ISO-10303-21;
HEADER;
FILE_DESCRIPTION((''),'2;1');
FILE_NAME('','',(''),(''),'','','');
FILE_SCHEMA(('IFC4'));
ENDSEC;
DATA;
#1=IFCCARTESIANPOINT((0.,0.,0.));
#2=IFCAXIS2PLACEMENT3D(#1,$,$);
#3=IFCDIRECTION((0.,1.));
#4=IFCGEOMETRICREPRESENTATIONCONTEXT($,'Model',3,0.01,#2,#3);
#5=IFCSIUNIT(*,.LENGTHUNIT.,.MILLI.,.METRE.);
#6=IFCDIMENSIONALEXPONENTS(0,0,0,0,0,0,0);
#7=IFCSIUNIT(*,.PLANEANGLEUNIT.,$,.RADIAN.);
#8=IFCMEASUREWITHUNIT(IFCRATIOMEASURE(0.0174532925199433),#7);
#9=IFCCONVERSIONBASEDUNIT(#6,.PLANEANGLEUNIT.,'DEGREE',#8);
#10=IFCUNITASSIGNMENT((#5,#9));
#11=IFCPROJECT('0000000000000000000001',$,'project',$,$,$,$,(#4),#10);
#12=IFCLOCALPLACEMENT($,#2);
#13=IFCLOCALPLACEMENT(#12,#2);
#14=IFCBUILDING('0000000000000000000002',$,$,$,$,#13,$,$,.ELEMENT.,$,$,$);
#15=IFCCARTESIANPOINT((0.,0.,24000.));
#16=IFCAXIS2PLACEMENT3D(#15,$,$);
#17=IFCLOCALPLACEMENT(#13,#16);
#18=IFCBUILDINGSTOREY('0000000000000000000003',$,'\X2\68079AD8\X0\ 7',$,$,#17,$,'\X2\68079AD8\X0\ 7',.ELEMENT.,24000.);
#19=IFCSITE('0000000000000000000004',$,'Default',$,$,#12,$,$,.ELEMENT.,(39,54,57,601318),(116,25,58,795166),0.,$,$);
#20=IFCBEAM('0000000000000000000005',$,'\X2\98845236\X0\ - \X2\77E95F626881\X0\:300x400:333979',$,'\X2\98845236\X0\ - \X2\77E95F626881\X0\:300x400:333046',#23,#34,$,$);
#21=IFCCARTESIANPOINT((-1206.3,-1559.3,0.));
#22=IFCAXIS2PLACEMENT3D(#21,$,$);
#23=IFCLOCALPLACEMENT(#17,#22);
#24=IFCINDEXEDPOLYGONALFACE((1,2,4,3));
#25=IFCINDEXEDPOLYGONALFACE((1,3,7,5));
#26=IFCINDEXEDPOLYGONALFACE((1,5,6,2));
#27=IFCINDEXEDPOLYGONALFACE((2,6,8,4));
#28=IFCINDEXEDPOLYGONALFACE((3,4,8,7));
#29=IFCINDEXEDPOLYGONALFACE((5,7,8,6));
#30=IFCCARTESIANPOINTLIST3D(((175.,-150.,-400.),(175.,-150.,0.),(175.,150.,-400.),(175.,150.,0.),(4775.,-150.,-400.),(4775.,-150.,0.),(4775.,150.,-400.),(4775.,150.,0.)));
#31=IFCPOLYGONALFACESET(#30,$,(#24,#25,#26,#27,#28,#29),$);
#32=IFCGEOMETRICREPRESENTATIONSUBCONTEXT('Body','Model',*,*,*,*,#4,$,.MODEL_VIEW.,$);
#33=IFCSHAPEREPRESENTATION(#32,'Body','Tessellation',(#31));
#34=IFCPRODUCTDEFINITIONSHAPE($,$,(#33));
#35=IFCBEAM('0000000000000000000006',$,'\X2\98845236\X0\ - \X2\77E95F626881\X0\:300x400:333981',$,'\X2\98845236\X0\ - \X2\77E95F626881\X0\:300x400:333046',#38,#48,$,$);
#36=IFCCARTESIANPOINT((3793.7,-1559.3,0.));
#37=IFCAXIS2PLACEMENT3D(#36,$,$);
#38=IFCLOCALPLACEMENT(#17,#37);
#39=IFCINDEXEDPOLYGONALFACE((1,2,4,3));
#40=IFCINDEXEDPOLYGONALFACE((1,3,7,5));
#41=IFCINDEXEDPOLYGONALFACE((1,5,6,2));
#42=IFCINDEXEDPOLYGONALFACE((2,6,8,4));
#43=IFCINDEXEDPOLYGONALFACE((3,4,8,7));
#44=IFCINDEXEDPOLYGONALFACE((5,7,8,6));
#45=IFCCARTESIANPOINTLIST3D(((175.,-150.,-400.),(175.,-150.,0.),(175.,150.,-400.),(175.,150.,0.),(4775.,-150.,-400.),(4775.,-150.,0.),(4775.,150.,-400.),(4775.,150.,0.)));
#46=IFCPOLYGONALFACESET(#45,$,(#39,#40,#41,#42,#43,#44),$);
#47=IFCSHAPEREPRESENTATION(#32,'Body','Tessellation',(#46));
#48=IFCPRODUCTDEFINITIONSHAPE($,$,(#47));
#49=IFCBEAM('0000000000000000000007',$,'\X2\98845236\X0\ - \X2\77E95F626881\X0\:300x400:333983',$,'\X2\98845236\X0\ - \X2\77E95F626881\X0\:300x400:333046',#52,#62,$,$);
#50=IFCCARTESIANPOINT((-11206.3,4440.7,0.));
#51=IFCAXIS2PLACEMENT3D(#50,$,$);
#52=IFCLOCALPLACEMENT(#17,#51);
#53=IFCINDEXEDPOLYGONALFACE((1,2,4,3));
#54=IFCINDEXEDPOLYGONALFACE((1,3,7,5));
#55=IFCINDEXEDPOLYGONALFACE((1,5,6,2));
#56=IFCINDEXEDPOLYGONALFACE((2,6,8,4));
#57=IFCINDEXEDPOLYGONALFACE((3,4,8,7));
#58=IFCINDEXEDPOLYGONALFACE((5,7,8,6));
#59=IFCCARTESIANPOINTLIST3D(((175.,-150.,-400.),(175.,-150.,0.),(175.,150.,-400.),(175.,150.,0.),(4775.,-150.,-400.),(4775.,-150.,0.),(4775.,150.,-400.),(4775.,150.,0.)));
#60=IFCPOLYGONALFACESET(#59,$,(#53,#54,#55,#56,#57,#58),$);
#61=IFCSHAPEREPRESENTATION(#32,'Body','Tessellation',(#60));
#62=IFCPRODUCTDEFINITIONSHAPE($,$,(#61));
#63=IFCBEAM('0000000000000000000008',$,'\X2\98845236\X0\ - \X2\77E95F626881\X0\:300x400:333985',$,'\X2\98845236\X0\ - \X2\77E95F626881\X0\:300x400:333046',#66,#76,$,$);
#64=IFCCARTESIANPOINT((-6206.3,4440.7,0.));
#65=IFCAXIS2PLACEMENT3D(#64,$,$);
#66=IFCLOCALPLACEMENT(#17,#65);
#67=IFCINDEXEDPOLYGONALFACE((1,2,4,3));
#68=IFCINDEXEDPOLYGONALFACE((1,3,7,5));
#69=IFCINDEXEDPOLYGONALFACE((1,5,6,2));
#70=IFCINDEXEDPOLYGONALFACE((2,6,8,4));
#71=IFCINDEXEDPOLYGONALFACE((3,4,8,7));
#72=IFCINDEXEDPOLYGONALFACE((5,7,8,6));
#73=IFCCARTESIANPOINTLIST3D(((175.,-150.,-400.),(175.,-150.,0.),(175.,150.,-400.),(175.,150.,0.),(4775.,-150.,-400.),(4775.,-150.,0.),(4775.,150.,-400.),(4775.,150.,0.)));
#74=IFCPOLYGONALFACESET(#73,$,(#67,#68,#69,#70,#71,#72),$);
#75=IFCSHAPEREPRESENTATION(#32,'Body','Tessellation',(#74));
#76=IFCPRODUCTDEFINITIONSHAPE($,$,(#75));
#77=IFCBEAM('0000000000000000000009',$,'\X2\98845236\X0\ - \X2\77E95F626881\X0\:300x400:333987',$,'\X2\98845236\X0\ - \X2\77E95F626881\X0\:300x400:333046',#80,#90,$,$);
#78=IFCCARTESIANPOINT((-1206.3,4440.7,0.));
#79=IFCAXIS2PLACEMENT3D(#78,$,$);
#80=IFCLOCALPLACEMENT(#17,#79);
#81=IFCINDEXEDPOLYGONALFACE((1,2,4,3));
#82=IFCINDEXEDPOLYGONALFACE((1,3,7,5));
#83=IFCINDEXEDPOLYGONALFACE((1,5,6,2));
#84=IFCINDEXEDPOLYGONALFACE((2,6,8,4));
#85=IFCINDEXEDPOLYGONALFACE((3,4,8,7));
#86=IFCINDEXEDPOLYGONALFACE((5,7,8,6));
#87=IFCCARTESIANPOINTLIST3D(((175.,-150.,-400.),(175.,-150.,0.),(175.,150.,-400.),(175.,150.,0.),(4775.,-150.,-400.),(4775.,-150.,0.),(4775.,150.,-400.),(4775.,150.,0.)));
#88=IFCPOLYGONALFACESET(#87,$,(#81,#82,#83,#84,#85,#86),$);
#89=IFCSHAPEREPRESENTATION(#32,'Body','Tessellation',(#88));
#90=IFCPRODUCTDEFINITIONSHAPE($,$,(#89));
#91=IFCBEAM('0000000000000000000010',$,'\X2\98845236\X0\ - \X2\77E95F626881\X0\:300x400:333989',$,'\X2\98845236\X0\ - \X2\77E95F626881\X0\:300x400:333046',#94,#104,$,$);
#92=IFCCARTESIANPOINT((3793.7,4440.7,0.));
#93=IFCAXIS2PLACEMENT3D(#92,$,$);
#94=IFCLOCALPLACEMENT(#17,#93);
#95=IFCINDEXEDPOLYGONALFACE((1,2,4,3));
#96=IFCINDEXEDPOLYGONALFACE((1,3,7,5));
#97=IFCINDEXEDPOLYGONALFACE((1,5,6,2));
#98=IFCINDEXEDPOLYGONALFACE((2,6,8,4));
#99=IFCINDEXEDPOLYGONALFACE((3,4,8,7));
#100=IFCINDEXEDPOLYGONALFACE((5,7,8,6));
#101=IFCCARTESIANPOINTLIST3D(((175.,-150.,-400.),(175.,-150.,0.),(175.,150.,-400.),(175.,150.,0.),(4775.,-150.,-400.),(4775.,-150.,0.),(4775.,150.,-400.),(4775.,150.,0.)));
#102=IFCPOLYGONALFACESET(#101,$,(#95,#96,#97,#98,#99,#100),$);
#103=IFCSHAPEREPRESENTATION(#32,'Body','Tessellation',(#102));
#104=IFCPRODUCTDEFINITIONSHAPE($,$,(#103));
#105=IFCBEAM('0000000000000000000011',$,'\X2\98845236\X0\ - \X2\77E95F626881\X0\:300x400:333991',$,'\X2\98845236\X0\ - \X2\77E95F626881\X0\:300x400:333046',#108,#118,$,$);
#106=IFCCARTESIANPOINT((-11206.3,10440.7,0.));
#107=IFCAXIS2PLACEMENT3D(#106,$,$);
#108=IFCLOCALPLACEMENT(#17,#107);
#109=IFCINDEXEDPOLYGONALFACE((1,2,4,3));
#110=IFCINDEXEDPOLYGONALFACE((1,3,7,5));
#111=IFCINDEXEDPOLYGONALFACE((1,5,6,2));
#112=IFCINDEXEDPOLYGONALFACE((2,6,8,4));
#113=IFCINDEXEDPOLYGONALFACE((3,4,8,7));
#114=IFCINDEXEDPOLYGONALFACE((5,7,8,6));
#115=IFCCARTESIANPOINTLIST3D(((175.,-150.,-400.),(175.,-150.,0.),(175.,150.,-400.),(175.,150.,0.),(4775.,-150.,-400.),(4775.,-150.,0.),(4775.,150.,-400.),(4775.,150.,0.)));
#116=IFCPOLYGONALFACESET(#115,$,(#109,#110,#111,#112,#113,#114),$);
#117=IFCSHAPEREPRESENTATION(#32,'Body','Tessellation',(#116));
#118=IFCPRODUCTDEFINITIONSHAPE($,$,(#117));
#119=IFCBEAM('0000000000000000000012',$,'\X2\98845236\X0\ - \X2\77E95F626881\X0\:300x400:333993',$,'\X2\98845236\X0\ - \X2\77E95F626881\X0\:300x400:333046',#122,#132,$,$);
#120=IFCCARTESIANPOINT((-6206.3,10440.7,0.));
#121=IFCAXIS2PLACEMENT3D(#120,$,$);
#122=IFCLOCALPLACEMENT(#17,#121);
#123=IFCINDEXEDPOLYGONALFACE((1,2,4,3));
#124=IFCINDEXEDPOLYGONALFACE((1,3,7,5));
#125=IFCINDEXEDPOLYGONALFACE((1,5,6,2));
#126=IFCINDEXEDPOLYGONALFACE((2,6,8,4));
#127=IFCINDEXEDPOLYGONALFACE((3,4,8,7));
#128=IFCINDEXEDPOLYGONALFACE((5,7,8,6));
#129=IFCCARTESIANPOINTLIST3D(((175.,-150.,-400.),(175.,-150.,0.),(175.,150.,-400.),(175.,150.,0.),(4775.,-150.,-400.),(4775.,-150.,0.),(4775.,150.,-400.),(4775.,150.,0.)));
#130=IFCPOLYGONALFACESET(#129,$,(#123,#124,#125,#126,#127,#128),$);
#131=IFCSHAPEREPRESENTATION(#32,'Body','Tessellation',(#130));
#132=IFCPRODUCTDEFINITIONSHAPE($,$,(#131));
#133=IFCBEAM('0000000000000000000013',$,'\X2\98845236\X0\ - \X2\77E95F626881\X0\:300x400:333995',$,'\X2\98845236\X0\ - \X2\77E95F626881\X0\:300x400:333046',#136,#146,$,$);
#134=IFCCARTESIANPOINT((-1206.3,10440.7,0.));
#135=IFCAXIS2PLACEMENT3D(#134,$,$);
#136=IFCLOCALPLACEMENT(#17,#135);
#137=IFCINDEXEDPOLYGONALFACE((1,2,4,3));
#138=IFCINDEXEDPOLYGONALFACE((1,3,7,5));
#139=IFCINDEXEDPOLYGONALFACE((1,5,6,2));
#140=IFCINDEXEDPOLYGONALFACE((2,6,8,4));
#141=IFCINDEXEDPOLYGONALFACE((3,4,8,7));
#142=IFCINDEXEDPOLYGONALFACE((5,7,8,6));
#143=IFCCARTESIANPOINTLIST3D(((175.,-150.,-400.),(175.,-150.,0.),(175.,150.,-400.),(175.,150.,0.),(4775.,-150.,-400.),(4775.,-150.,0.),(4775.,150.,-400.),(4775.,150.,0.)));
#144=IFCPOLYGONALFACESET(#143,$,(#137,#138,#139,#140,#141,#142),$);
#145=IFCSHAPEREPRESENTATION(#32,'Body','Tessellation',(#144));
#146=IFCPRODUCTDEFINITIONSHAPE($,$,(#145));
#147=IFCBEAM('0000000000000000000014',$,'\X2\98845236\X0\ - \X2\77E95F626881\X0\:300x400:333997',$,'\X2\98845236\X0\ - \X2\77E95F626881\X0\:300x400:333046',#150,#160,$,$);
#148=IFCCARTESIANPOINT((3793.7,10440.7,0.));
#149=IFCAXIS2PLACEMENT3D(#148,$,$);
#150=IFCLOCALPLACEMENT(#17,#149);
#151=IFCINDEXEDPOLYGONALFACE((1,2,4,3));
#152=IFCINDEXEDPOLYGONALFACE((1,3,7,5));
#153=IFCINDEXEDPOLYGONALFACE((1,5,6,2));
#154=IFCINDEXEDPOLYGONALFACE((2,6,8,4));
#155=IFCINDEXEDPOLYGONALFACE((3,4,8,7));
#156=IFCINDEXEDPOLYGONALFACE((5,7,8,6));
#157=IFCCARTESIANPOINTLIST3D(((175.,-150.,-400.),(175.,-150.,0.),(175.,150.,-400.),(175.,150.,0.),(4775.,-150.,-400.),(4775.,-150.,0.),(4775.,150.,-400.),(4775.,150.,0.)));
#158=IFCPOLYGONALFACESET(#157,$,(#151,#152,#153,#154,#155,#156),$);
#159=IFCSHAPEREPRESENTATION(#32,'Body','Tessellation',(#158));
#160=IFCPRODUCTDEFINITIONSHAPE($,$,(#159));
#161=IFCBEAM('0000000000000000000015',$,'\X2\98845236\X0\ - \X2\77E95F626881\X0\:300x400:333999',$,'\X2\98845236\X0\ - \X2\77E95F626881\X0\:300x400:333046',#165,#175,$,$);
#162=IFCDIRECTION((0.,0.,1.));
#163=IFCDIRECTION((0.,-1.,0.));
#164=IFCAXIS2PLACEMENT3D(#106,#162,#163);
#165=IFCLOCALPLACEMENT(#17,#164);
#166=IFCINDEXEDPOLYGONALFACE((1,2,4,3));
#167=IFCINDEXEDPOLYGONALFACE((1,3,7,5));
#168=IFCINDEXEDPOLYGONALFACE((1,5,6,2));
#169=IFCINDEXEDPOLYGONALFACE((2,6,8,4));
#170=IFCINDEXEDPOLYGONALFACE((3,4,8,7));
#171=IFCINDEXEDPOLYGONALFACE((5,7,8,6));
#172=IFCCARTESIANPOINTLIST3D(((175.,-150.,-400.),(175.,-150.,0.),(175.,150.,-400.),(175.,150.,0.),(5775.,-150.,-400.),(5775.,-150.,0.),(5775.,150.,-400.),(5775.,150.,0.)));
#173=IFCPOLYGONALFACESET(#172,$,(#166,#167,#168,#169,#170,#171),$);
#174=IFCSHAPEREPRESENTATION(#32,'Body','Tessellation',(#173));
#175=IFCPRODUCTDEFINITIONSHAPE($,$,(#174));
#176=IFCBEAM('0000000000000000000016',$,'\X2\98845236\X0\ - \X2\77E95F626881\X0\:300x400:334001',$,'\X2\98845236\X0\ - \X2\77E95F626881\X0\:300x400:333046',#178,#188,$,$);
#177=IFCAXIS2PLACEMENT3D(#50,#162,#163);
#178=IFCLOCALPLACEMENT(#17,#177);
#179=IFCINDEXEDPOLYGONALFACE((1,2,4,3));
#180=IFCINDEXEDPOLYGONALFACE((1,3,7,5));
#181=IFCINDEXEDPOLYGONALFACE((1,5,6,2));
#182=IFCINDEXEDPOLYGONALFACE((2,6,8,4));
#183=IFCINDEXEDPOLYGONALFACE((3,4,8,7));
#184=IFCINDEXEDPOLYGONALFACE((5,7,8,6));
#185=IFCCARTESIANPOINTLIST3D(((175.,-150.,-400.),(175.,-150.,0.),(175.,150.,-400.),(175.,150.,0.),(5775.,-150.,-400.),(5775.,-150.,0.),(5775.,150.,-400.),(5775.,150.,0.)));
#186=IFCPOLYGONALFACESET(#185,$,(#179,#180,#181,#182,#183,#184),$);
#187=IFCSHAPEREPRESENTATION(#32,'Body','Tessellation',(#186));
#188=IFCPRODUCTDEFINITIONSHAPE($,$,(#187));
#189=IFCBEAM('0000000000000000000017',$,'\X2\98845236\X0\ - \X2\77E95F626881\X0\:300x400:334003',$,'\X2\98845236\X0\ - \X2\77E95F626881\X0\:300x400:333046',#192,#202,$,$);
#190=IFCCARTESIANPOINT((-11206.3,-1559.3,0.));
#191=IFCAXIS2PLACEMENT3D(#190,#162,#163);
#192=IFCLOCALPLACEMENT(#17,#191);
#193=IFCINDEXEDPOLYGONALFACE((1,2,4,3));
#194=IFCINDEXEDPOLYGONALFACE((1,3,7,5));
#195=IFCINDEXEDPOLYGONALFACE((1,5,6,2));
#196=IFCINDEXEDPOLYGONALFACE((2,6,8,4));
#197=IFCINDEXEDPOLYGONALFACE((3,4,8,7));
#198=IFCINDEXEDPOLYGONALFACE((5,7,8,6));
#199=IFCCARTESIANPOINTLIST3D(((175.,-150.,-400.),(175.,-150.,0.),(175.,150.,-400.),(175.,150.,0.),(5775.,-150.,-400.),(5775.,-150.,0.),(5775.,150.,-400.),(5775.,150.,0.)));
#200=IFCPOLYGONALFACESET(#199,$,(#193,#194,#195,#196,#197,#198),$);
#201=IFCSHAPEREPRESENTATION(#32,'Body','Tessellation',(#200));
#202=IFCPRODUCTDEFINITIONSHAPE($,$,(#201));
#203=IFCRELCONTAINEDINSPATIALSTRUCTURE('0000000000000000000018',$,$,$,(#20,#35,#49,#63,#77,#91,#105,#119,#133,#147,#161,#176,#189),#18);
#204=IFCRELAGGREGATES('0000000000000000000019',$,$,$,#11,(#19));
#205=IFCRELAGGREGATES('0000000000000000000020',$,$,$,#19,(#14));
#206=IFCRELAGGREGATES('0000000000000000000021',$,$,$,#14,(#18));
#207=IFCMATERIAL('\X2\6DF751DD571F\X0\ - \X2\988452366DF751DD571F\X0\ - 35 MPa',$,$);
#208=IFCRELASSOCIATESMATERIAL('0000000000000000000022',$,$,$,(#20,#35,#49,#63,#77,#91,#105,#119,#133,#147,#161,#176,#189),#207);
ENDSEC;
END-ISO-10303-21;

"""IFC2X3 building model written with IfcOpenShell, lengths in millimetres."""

from ifc_helpers import new_model, entity, si_unit, converted_unit, direction, frame, frame_2d, origin, origin_2d_with_axis, place, context, subcontext, project, spatial, rectangle, extrude, material, element, save


model = new_model("IFC2X3")

# Units and contexts
model_context = context("Model", 3, precision=0.01, world=origin(), true_north=direction((0.0, 1.0)))
body_context = subcontext(model_context, "Body", "Model", "MODEL_VIEW")
ifc_project = project(units=[si_unit("LENGTHUNIT", "METRE", prefix="MILLI"), converted_unit("PLANEANGLEUNIT", "DEGREE", entity("IfcRatioMeasure", 0.0174532925199433), si_unit("PLANEANGLEUNIT", "RADIAN"), dimensions=[0, 0, 0, 0, 0, 0, 0])], contexts=[model_context])

# Site, building, storey
site_placement = place(None, origin())
site = spatial("IfcSite", under=ifc_project, at=site_placement, Name="Default", CompositionType="ELEMENT", RefLatitude=(39, 54, 57, 601318), RefLongitude=(116, 25, 58, 795166), RefElevation=0.0)
building_placement = place(site_placement, origin())
building = spatial("IfcBuilding", under=site, at=building_placement, CompositionType="ELEMENT")
storey_placement = place(building_placement, frame((0.0, 0.0, 24000.0)))
storey = spatial("IfcBuildingStorey", under=building, at=storey_placement, Name="标高 7", LongName="标高 7", CompositionType="ELEMENT", Elevation=24000.0)

# Beams
ifc_material_1 = material(Name="混凝土 - 预制混凝土 - 35 MPa")
beam_1_placement = place(storey_placement, frame((-1206.3, -1559.3, 0.0)))
element("IfcBeam", 1, at=beam_1_placement, inside=storey, material=ifc_material_1, Name="预制 - 矩形梁:300x400:333979", ObjectType="预制 - 矩形梁:300x400:333046", context=body_context, shape_type="SweptSolid", body=[
    extrude(rectangle(XDim=400.0, YDim=300.0, at=frame_2d((0.0, 0.0), x_axis=(1.0, 0.0))), frame((175.0, 0.0, -200.0), z_axis=(1.0, 0.0, 0.0), x_axis=(0.0, 0.0, -1.0)), (0.0, 0.0, 1.0), 4600.0),
])
beam_2_placement = place(storey_placement, frame((3793.7, -1559.3, 0.0)))
element("IfcBeam", 2, at=beam_2_placement, inside=storey, material=ifc_material_1, Name="预制 - 矩形梁:300x400:333981", ObjectType="预制 - 矩形梁:300x400:333046", context=body_context, shape_type="SweptSolid", body=[
    extrude(rectangle(XDim=400.0, YDim=300.0, at=frame_2d((0.0, 0.0), x_axis=(1.0, 0.0))), frame((175.0, 0.0, -200.0), z_axis=(1.0, 0.0, 0.0), x_axis=(0.0, 0.0, -1.0)), (0.0, 0.0, 1.0), 4600.0),
])
beam_3_placement = place(storey_placement, frame((-11206.3, 4440.7, 0.0)))
element("IfcBeam", 3, at=beam_3_placement, inside=storey, material=ifc_material_1, Name="预制 - 矩形梁:300x400:333983", ObjectType="预制 - 矩形梁:300x400:333046", context=body_context, shape_type="SweptSolid", body=[
    extrude(rectangle(XDim=400.0, YDim=300.0, at=frame_2d((0.0, 0.0), x_axis=(1.0, 0.0))), frame((175.0, 0.0, -200.0), z_axis=(1.0, 0.0, 0.0), x_axis=(0.0, 0.0, -1.0)), (0.0, 0.0, 1.0), 4600.0),
])
beam_4_placement = place(storey_placement, frame((-6206.3, 4440.7, 0.0)))
element("IfcBeam", 4, at=beam_4_placement, inside=storey, material=ifc_material_1, Name="预制 - 矩形梁:300x400:333985", ObjectType="预制 - 矩形梁:300x400:333046", context=body_context, shape_type="SweptSolid", body=[
    extrude(rectangle(XDim=400.0, YDim=300.0, at=frame_2d((0.0, 0.0), x_axis=(1.0, 0.0))), frame((175.0, 0.0, -200.0), z_axis=(1.0, 0.0, 0.0), x_axis=(0.0, 0.0, -1.0)), (0.0, 0.0, 1.0), 4600.0),
])
beam_5_placement = place(storey_placement, frame((-1206.3, 4440.7, 0.0)))
element("IfcBeam", 5, at=beam_5_placement, inside=storey, material=ifc_material_1, Name="预制 - 矩形梁:300x400:333987", ObjectType="预制 - 矩形梁:300x400:333046", context=body_context, shape_type="SweptSolid", body=[
    extrude(rectangle(XDim=400.0, YDim=300.0, at=frame_2d((0.0, 0.0), x_axis=(1.0, 0.0))), frame((175.0, 0.0, -200.0), z_axis=(1.0, 0.0, 0.0), x_axis=(0.0, 0.0, -1.0)), (0.0, 0.0, 1.0), 4600.0),
])
beam_6_placement = place(storey_placement, frame((3793.7, 4440.7, 0.0)))
element("IfcBeam", 6, at=beam_6_placement, inside=storey, material=ifc_material_1, Name="预制 - 矩形梁:300x400:333989", ObjectType="预制 - 矩形梁:300x400:333046", context=body_context, shape_type="SweptSolid", body=[
    extrude(rectangle(XDim=400.0, YDim=300.0, at=frame_2d((0.0, 0.0), x_axis=(1.0, 0.0))), frame((175.0, 0.0, -200.0), z_axis=(1.0, 0.0, 0.0), x_axis=(0.0, 0.0, -1.0)), (0.0, 0.0, 1.0), 4600.0),
])
beam_7_placement = place(storey_placement, frame((-11206.3, 10440.7, 0.0)))
element("IfcBeam", 7, at=beam_7_placement, inside=storey, material=ifc_material_1, Name="预制 - 矩形梁:300x400:333991", ObjectType="预制 - 矩形梁:300x400:333046", context=body_context, shape_type="SweptSolid", body=[
    extrude(rectangle(XDim=400.0, YDim=300.0, at=frame_2d((0.0, 0.0), x_axis=(1.0, 0.0))), frame((175.0, 0.0, -200.0), z_axis=(1.0, 0.0, 0.0), x_axis=(0.0, 0.0, -1.0)), (0.0, 0.0, 1.0), 4600.0),
])
beam_8_placement = place(storey_placement, frame((-6206.3, 10440.7, 0.0)))
element("IfcBeam", 8, at=beam_8_placement, inside=storey, material=ifc_material_1, Name="预制 - 矩形梁:300x400:333993", ObjectType="预制 - 矩形梁:300x400:333046", context=body_context, shape_type="SweptSolid", body=[
    extrude(rectangle(XDim=400.0, YDim=300.0, at=frame_2d((0.0, 0.0), x_axis=(1.0, 0.0))), frame((175.0, 0.0, -200.0), z_axis=(1.0, 0.0, 0.0), x_axis=(0.0, 0.0, -1.0)), (0.0, 0.0, 1.0), 4600.0),
])
beam_9_placement = place(storey_placement, frame((-1206.3, 10440.7, 0.0)))
element("IfcBeam", 9, at=beam_9_placement, inside=storey, material=ifc_material_1, Name="预制 - 矩形梁:300x400:333995", ObjectType="预制 - 矩形梁:300x400:333046", context=body_context, shape_type="SweptSolid", body=[
    extrude(rectangle(XDim=400.0, YDim=300.0, at=frame_2d((0.0, 0.0), x_axis=(1.0, 0.0))), frame((175.0, 0.0, -200.0), z_axis=(1.0, 0.0, 0.0), x_axis=(0.0, 0.0, -1.0)), (0.0, 0.0, 1.0), 4600.0),
])
beam_10_placement = place(storey_placement, frame((3793.7, 10440.7, 0.0)))
element("IfcBeam", 10, at=beam_10_placement, inside=storey, material=ifc_material_1, Name="预制 - 矩形梁:300x400:333997", ObjectType="预制 - 矩形梁:300x400:333046", context=body_context, shape_type="SweptSolid", body=[
    extrude(rectangle(XDim=400.0, YDim=300.0, at=frame_2d((0.0, 0.0), x_axis=(1.0, 0.0))), frame((175.0, 0.0, -200.0), z_axis=(1.0, 0.0, 0.0), x_axis=(0.0, 0.0, -1.0)), (0.0, 0.0, 1.0), 4600.0),
])
for number, where, z_axis, x_axis, name in (
    (11, (-11206.3, 10440.7, 0.0), (0.0, 0.0, 1.0), (0.0, -1.0, 0.0), "预制 - 矩形梁:300x400:333999"),
    (12, (-11206.3, 4440.7, 0.0), (0.0, 0.0, 1.0), (0.0, -1.0, 0.0), "预制 - 矩形梁:300x400:334001"),
):
    element("IfcBeam", number, at=place(storey_placement, frame(where, z_axis=z_axis, x_axis=x_axis)), inside=storey, material=ifc_material_1, Name=name, ObjectType="预制 - 矩形梁:300x400:333046", context=body_context, shape_type="SweptSolid", body=[
        extrude(rectangle(XDim=400.0, YDim=300.0, at=origin_2d_with_axis()), frame((175.0, 0.0, -200.0), z_axis=(1.0, 0.0, 0.0), x_axis=(0.0, 0.0, -1.0)), (0.0, 0.0, 1.0), 5600.0),
    ])
beam_11_placement = place(storey_placement, frame((-11206.3, -1559.3, 0.0), z_axis=(0.0, 0.0, 1.0), x_axis=(0.0, -1.0, 0.0)))
element("IfcBeam", 13, at=beam_11_placement, inside=storey, material=ifc_material_1, Name="预制 - 矩形梁:300x400:334003", ObjectType="预制 - 矩形梁:300x400:333046", context=body_context, shape_type="SweptSolid", body=[
    extrude(rectangle(XDim=400.0, YDim=300.0, at=frame_2d((0.0, 0.0), x_axis=(1.0, 0.0))), frame((175.0, 0.0, -200.0), z_axis=(1.0, 0.0, 0.0), x_axis=(0.0, 0.0, -1.0)), (0.0, 0.0, 1.0), 5600.0),
])

save(model, "model.ifc")
